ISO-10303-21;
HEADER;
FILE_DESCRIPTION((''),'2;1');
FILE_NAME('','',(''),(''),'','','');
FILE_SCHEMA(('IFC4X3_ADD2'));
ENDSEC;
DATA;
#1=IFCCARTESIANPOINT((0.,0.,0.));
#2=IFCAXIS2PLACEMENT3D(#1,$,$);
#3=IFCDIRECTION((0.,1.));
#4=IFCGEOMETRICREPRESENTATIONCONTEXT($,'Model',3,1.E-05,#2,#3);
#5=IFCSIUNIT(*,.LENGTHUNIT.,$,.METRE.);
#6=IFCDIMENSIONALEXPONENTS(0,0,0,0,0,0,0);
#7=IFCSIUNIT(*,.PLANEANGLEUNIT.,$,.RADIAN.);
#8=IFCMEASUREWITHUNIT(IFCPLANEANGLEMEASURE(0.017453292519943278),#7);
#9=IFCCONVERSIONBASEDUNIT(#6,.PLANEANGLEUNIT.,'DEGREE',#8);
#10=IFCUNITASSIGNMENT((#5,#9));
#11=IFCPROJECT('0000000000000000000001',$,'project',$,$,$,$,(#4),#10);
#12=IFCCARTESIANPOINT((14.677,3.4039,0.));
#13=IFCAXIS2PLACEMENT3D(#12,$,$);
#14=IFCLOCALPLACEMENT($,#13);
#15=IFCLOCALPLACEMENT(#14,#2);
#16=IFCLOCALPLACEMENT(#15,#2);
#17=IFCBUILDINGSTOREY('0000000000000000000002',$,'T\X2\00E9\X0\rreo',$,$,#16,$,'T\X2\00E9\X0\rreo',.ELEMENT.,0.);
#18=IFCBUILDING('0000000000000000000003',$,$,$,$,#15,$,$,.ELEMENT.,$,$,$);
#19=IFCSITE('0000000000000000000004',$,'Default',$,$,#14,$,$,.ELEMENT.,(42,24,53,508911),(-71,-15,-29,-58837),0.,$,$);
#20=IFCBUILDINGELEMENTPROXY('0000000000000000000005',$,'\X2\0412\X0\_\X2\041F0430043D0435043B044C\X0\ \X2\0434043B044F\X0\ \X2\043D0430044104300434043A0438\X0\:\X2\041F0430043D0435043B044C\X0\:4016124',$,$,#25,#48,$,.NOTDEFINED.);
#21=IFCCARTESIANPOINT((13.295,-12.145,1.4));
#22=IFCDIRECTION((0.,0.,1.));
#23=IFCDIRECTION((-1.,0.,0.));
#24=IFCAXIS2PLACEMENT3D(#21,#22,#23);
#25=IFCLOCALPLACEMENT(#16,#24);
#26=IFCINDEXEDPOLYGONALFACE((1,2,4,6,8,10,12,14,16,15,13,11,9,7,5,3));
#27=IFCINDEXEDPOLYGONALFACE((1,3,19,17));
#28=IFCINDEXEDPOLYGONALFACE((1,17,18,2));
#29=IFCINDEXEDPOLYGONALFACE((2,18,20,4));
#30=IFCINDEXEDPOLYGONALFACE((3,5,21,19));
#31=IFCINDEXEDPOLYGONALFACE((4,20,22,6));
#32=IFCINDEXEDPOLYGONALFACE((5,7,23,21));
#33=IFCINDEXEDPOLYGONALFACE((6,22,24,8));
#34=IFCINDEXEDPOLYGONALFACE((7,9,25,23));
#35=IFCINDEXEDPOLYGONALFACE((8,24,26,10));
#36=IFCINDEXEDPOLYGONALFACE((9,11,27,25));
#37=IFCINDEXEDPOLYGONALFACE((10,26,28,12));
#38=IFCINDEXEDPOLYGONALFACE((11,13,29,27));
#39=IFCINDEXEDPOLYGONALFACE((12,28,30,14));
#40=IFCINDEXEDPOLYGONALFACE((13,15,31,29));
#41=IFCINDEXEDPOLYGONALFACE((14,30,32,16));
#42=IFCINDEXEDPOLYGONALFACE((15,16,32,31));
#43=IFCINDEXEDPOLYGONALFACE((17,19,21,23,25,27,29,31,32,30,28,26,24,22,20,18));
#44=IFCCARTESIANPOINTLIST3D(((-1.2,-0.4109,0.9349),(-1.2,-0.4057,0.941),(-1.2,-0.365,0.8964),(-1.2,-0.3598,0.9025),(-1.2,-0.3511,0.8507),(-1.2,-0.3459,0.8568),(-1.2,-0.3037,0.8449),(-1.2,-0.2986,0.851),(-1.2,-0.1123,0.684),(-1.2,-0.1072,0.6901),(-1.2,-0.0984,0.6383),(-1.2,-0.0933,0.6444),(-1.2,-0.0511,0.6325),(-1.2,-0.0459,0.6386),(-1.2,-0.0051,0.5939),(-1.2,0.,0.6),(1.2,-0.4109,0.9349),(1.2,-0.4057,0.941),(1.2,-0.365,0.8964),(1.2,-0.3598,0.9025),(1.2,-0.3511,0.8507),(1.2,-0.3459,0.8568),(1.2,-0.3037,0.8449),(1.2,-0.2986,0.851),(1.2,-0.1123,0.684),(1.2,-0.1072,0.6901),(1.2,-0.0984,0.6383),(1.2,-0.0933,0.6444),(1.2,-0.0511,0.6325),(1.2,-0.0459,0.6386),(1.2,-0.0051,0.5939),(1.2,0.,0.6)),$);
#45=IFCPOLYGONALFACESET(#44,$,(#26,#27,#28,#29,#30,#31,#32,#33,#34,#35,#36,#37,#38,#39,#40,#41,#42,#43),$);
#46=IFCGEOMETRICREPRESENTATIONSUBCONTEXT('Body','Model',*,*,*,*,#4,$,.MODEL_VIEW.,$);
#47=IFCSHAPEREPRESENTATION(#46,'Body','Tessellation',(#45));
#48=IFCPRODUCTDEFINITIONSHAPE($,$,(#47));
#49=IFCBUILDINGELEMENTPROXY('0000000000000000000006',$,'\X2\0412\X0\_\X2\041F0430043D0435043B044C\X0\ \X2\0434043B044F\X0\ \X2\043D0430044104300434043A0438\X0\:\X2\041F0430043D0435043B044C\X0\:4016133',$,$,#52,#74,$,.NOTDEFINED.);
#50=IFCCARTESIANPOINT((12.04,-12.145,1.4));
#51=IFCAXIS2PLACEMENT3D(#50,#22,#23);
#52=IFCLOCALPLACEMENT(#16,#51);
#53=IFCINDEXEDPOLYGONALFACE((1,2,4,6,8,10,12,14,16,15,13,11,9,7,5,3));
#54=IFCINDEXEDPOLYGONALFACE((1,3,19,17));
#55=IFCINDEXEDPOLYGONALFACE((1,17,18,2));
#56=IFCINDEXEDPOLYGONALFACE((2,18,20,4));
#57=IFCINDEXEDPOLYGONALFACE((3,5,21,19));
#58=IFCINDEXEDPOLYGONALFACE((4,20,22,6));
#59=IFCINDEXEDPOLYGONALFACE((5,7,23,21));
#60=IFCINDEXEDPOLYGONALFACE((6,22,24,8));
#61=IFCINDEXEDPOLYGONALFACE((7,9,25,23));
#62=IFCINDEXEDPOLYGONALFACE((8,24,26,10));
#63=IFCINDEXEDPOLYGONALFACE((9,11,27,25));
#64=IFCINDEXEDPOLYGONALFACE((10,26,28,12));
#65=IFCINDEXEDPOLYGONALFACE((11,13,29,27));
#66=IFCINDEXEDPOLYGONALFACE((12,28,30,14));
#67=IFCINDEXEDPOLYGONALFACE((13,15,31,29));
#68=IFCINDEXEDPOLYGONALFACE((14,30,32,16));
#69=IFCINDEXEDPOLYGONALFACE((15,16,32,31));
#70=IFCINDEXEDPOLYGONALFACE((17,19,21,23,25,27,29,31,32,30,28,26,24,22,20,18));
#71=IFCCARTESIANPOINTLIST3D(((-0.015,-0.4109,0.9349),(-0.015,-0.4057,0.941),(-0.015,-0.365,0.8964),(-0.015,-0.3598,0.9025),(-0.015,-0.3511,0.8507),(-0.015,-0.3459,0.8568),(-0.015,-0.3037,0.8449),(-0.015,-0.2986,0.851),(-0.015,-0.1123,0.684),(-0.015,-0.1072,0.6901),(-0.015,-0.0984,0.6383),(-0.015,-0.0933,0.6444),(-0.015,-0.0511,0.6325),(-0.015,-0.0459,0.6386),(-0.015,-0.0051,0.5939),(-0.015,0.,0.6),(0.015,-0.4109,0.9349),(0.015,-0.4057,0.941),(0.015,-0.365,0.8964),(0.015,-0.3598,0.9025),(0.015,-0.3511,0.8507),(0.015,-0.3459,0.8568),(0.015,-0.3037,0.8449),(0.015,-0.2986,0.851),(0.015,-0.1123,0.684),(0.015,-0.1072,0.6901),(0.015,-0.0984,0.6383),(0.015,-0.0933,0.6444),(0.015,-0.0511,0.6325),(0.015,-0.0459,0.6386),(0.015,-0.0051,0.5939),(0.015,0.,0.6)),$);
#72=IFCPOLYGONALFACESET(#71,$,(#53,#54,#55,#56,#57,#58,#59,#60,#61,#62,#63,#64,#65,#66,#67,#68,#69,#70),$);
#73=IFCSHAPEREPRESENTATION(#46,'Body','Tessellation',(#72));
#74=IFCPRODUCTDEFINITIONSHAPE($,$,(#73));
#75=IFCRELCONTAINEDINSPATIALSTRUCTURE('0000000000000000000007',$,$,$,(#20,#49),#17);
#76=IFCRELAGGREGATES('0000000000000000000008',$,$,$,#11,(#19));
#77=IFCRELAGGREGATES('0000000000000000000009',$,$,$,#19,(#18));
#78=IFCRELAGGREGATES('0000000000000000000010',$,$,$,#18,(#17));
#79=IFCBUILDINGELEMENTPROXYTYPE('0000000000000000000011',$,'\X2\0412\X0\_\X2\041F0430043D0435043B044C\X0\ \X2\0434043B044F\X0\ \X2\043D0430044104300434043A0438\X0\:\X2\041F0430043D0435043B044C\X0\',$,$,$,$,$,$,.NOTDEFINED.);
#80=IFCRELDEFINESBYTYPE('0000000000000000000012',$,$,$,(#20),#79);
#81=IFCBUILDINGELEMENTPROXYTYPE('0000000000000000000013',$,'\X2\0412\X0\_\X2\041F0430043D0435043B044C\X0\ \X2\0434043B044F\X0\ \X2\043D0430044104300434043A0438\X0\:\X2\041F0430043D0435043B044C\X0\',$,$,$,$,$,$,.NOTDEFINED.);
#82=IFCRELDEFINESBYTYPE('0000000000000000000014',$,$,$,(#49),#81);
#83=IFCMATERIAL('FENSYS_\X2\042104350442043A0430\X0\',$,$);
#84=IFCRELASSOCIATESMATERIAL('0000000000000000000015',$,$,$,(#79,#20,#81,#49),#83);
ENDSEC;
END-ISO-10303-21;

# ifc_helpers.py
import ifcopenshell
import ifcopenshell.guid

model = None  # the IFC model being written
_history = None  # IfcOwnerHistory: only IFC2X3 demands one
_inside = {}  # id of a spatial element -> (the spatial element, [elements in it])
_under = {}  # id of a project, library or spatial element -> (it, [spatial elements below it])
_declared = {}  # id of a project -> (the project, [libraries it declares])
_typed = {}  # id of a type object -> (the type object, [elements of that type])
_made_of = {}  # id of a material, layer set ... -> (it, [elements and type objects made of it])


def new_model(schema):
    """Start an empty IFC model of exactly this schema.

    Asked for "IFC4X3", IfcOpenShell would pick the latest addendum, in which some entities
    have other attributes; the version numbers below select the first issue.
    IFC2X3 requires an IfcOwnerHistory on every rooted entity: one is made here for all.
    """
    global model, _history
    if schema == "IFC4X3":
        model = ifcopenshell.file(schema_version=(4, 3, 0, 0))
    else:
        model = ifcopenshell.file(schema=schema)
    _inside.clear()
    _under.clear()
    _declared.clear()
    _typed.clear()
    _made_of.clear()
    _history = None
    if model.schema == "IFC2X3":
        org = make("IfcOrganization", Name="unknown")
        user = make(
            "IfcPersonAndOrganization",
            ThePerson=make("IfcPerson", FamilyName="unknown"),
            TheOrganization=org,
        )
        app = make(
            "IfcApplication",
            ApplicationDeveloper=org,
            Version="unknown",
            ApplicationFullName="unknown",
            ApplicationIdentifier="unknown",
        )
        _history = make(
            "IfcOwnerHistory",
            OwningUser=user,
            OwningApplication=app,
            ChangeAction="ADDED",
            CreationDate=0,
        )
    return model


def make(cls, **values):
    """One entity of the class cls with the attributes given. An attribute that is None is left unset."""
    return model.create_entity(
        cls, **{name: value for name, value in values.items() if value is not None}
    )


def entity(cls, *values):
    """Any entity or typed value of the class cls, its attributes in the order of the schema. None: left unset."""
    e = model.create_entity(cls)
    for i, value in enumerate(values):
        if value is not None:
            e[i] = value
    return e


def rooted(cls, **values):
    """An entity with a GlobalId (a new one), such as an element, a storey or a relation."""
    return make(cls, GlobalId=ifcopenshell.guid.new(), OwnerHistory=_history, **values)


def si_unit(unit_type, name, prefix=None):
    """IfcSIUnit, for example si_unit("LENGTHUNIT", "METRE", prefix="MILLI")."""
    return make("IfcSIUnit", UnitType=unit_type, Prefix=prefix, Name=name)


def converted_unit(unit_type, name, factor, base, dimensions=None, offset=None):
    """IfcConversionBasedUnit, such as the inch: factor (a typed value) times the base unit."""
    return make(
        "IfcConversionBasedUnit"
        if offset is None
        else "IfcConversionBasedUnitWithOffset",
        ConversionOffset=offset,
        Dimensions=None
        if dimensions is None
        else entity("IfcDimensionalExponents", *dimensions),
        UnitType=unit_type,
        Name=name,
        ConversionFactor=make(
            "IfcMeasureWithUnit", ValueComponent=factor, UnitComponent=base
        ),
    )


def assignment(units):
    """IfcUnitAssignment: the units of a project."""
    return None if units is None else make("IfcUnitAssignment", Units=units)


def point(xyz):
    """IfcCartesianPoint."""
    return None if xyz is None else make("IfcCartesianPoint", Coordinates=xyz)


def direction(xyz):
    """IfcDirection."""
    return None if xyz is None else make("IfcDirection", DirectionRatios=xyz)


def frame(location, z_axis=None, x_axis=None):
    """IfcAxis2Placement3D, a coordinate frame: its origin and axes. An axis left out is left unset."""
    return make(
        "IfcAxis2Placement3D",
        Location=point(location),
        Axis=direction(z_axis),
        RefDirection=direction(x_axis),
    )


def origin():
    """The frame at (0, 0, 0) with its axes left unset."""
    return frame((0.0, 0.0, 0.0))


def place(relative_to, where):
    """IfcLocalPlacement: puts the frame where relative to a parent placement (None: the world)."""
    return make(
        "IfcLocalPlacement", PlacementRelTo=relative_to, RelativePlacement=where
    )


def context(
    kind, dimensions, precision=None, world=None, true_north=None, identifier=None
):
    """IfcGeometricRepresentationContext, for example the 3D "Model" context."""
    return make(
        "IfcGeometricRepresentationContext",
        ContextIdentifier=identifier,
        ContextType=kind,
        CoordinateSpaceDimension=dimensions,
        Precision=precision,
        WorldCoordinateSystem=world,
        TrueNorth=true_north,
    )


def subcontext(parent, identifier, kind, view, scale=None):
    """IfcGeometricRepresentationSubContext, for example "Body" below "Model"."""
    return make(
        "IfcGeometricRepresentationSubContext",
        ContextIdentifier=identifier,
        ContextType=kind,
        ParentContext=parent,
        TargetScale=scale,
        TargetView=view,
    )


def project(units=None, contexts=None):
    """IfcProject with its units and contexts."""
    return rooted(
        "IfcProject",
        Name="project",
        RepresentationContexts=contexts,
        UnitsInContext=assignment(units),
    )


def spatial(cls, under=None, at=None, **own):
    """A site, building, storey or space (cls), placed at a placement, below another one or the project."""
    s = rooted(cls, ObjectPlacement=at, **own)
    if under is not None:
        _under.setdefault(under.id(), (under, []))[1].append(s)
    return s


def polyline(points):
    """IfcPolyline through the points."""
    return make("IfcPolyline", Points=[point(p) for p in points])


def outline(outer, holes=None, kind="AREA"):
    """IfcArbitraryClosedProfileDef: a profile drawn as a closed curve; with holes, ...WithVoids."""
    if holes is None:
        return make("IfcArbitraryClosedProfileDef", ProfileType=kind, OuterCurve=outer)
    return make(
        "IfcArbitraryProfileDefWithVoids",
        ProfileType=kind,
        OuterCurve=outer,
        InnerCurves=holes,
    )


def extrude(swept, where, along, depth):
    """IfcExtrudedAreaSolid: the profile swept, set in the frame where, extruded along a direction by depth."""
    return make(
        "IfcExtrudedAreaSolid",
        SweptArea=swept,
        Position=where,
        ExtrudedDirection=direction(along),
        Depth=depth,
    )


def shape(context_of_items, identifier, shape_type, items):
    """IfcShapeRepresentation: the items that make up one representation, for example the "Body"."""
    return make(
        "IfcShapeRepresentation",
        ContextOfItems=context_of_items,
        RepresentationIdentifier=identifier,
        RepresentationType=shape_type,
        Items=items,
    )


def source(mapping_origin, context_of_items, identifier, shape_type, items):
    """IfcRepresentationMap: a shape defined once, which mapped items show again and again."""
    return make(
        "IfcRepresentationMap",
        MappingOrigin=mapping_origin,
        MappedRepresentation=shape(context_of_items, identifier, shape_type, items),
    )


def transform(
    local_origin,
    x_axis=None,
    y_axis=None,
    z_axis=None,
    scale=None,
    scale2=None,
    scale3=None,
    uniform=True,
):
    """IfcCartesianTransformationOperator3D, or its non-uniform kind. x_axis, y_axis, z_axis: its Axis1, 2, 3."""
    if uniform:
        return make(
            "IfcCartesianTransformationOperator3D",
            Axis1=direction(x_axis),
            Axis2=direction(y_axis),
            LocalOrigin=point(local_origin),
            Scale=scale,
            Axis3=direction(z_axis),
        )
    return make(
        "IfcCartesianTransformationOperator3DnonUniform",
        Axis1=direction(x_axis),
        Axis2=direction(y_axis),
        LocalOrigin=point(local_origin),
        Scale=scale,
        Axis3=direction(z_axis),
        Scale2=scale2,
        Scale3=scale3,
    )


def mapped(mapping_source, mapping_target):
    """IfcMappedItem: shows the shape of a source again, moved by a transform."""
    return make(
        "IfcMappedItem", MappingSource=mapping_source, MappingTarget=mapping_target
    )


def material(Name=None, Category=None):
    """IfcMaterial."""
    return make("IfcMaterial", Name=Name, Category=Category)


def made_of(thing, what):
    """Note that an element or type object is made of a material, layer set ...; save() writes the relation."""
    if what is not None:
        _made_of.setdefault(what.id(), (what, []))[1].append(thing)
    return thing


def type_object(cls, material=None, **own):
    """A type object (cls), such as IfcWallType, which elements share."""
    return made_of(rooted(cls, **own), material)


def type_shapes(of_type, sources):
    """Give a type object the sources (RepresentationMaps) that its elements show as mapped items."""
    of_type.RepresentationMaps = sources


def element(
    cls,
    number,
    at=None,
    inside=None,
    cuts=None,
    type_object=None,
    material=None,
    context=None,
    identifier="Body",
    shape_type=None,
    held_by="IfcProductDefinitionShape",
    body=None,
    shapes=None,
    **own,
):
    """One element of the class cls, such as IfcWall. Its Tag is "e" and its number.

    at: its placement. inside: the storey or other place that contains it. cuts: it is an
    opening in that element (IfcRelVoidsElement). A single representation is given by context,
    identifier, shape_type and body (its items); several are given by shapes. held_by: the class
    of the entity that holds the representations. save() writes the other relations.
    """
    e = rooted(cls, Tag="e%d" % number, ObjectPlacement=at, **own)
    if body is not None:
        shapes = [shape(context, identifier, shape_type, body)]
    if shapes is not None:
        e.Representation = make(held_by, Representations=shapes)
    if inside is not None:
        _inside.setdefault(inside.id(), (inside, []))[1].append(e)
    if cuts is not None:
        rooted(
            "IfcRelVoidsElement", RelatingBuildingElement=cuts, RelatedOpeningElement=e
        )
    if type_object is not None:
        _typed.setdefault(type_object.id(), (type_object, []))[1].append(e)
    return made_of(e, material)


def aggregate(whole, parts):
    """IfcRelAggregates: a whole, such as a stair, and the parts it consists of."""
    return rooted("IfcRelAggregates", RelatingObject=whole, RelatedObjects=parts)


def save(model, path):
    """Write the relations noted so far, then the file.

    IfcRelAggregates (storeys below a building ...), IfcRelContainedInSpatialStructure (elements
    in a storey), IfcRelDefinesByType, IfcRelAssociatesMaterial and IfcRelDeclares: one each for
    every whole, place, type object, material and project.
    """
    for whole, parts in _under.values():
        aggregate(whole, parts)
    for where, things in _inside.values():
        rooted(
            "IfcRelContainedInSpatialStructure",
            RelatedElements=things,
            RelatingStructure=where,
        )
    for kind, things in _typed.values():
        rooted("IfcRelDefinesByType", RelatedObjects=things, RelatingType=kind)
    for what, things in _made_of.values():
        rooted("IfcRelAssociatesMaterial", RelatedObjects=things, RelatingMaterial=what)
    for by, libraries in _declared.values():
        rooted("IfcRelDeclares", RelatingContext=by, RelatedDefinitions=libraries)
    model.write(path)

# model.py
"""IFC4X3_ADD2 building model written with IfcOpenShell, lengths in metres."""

from ifc_helpers import new_model, entity, si_unit, converted_unit, direction, frame, origin, place, context, subcontext, project, spatial, polyline, outline, extrude, source, transform, mapped, material, type_object, type_shapes, element, save


model = new_model("IFC4X3_ADD2")

# Units and contexts
model_context = context("Model", 3, precision=1e-05, world=origin(), true_north=direction((0.0, 1.0)))
body_context = subcontext(model_context, "Body", "Model", "MODEL_VIEW")
ifc_project = project(units=[si_unit("LENGTHUNIT", "METRE"), converted_unit("PLANEANGLEUNIT", "DEGREE", entity("IfcPlaneAngleMeasure", 0.017453292519943278), si_unit("PLANEANGLEUNIT", "RADIAN"), dimensions=[0, 0, 0, 0, 0, 0, 0])], contexts=[model_context])

# Site, building, storey
site_placement = place(None, frame((14.677, 3.4039, 0.0)))
site = spatial("IfcSite", under=ifc_project, at=site_placement, Name="Default", CompositionType="ELEMENT", RefLatitude=(42, 24, 53, 508911), RefLongitude=(-71, -15, -29, -58837), RefElevation=0.0)
building_placement = place(site_placement, origin())
building = spatial("IfcBuilding", under=site, at=building_placement, CompositionType="ELEMENT")
storey_placement = place(building_placement, origin())
storey = spatial("IfcBuildingStorey", under=building, at=storey_placement, Name="Térreo", LongName="Térreo", CompositionType="ELEMENT", Elevation=0.0)

# Building element proxies
ifc_material_1 = material(Name="FENSYS_Сетка")
building_element_proxy_type_1 = type_object("IfcBuildingElementProxyType", Name="В_Панель для насадки:Панель", PredefinedType="NOTDEFINED", material=ifc_material_1)
shared_shape_1 = source(origin(), body_context, "Body", "SweptSolid", [
    extrude(outline(polyline([(0.205, -0.0105), (0.265, -0.0105), (0.265, -0.0025), (0.205, -0.0025), (0.165, 0.0235), (0.125, -0.0025), (-0.125, -0.0025), (-0.165, 0.0235), (-0.205, -0.0025), (-0.265, -0.0025), (-0.265, -0.0105), (-0.205, -0.0105), (-0.165, 0.0155), (-0.125, -0.0105), (0.125, -0.0105), (0.165, 0.0155), (0.205, -0.0105)])), frame((-1.2, -0.2096, 0.7625), z_axis=(1.0, 0.0, 0.0), x_axis=(0.0, -0.765483, 0.643456)), (0.0, 0.0, 1.0), 2.4),
])
type_shapes(building_element_proxy_type_1, [shared_shape_1])
proxy_1_placement = place(storey_placement, frame((13.295, -12.145, 1.4), z_axis=(0.0, 0.0, 1.0), x_axis=(-1.0, 0.0, 0.0)))
element("IfcBuildingElementProxy", 1, at=proxy_1_placement, inside=storey, type_object=building_element_proxy_type_1, material=ifc_material_1, Name="В_Панель для насадки:Панель:4016124", PredefinedType="NOTDEFINED", context=body_context, shape_type="MappedRepresentation", body=[
    mapped(shared_shape_1, transform((0.0, 0.0, 0.0), scale=1.0)),
])
building_element_proxy_type_2 = type_object("IfcBuildingElementProxyType", Name="В_Панель для насадки:Панель", PredefinedType="NOTDEFINED", material=ifc_material_1)
shared_shape_2 = source(origin(), body_context, "Body", "SweptSolid", [
    extrude(outline(polyline([(0.205, -0.0105), (0.265, -0.0105), (0.265, -0.0025), (0.205, -0.0025), (0.165, 0.0235), (0.125, -0.0025), (-0.125, -0.0025), (-0.165, 0.0235), (-0.205, -0.0025), (-0.265, -0.0025), (-0.265, -0.0105), (-0.205, -0.0105), (-0.165, 0.0155), (-0.125, -0.0105), (0.125, -0.0105), (0.165, 0.0155), (0.205, -0.0105)])), frame((-0.015, -0.2096, 0.7625), z_axis=(1.0, 0.0, 0.0), x_axis=(0.0, -0.765483, 0.643456)), (0.0, 0.0, 1.0), 0.03),
])
type_shapes(building_element_proxy_type_2, [shared_shape_2])
proxy_2_placement = place(storey_placement, frame((12.04, -12.145, 1.4), z_axis=(0.0, 0.0, 1.0), x_axis=(-1.0, 0.0, 0.0)))
element("IfcBuildingElementProxy", 2, at=proxy_2_placement, inside=storey, type_object=building_element_proxy_type_2, material=ifc_material_1, Name="В_Панель для насадки:Панель:4016133", PredefinedType="NOTDEFINED", context=body_context, shape_type="MappedRepresentation", body=[
    mapped(shared_shape_2, transform((0.0, 0.0, 0.0), scale=1.0)),
])

save(model, "model.ifc")
